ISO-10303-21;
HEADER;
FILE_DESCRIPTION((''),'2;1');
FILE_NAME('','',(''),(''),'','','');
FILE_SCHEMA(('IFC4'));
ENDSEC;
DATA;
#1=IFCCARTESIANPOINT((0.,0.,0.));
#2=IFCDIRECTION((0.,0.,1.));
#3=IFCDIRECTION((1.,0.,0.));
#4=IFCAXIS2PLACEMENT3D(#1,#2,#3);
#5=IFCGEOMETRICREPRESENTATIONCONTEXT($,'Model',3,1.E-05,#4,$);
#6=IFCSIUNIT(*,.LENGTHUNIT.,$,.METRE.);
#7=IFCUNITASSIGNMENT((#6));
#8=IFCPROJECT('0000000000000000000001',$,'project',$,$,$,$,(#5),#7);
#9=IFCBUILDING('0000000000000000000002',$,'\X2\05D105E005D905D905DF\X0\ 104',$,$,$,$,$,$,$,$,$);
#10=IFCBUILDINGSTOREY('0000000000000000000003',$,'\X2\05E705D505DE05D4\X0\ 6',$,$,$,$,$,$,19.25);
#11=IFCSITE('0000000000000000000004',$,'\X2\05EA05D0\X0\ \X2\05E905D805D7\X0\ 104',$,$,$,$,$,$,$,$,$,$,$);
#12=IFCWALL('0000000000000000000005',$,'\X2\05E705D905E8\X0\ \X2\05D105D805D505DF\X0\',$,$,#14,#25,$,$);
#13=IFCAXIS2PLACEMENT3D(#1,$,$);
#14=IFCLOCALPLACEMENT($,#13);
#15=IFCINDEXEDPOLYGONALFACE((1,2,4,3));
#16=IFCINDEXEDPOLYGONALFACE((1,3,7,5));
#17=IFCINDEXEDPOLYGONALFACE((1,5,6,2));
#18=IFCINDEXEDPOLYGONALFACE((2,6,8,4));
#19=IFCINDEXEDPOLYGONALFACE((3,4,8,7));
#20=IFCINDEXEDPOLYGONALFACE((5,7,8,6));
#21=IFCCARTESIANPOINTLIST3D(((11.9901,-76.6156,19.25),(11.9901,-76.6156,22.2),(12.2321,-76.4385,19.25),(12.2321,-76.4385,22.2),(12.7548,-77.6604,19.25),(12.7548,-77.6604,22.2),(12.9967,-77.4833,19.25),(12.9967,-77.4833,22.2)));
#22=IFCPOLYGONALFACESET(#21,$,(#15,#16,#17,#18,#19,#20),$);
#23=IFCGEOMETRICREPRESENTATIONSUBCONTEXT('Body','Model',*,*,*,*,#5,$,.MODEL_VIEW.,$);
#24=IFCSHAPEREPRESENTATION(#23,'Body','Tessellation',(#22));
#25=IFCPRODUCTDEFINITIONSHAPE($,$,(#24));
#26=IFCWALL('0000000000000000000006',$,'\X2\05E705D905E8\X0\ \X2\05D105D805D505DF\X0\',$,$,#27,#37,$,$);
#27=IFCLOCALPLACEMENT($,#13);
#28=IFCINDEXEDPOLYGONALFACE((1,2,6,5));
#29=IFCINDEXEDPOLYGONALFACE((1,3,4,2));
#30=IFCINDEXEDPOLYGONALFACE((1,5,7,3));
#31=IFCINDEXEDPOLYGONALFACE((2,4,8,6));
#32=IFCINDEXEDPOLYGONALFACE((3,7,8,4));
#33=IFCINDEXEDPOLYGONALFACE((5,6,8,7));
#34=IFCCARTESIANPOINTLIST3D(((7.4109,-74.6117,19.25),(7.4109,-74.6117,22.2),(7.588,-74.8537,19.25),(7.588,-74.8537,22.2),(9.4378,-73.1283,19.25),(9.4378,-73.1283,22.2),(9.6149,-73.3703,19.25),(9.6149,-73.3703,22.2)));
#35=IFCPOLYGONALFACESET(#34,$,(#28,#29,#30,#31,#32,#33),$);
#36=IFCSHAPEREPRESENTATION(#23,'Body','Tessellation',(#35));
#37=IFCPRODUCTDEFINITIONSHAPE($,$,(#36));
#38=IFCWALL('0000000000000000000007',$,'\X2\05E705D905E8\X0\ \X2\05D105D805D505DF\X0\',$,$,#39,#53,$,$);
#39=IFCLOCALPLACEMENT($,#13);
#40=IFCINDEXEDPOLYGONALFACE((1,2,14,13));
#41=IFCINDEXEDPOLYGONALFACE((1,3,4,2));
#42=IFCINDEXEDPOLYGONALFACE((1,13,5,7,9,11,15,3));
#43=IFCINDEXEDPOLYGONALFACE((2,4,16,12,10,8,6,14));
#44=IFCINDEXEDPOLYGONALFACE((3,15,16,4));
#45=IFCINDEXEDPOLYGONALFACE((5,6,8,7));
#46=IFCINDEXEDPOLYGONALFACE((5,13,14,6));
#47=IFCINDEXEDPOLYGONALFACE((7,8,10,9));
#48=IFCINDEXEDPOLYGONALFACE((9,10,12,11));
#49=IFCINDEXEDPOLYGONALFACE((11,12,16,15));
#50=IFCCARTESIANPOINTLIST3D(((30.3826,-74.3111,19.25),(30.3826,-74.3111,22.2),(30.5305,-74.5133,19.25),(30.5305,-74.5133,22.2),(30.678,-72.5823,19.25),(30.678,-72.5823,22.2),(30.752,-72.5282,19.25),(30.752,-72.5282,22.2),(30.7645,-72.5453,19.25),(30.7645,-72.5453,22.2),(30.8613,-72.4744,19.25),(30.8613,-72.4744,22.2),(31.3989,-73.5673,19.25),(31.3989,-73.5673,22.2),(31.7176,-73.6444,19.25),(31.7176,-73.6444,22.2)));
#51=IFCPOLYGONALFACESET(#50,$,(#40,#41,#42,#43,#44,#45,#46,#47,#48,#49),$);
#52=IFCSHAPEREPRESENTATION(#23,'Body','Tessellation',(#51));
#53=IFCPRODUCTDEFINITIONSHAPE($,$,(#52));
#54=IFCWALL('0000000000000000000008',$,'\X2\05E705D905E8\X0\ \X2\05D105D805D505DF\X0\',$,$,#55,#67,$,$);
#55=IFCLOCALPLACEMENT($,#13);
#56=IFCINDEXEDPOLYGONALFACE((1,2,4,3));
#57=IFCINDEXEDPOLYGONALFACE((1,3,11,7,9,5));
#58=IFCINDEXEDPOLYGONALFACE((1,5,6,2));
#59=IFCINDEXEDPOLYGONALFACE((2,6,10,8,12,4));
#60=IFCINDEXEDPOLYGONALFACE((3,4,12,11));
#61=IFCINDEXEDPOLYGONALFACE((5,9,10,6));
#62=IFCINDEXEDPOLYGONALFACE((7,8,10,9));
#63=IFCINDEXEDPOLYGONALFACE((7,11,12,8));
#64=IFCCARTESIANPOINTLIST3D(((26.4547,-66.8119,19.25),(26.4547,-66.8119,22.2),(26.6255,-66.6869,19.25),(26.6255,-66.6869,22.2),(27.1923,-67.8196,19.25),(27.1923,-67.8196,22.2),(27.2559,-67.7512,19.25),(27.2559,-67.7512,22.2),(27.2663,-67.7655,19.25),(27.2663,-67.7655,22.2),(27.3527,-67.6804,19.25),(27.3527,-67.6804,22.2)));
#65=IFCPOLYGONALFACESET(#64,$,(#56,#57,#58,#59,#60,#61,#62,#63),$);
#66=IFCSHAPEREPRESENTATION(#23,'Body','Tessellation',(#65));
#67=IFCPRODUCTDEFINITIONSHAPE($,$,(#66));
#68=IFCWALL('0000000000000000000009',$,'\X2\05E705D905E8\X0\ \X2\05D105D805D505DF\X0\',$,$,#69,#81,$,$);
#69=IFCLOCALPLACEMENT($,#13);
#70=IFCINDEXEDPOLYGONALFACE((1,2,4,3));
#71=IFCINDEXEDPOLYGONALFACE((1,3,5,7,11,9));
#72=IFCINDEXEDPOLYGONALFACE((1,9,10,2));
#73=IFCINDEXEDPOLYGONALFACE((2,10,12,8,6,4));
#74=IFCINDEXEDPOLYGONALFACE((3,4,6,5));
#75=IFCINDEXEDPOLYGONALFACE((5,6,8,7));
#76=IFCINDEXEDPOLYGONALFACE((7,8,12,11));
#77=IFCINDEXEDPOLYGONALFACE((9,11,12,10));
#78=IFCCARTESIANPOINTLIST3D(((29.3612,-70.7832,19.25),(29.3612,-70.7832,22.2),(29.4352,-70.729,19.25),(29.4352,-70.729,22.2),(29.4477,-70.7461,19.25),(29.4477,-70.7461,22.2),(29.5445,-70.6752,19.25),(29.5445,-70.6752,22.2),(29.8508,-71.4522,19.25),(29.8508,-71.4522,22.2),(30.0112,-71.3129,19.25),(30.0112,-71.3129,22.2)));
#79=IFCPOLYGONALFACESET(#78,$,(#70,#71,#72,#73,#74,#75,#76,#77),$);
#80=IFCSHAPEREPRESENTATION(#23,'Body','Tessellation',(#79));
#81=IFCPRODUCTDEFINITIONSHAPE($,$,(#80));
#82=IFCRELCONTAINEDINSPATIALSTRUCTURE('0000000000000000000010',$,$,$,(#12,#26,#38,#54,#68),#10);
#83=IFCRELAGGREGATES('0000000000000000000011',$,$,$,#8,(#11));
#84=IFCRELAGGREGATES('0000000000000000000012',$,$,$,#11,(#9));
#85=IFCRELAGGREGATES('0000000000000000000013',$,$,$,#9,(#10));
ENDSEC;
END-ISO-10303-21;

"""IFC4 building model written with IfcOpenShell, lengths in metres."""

from ifc_helpers import new_model, si_unit, frame, origin_with_axes, context, subcontext, project, spatial, polyline, outline, extrude, element, save


model = new_model("IFC4")

# Units and contexts
model_context = context("Model", 3, precision=1e-05, world=origin_with_axes())
body_context = subcontext(model_context, "Body", "Model", "MODEL_VIEW")
ifc_project = project(units=[si_unit("LENGTHUNIT", "METRE")], contexts=[model_context])

# Site, building, storey
site = spatial("IfcSite", under=ifc_project, Name="תא שטח 104")
building = spatial("IfcBuilding", under=site, Name="בניין 104")
storey = spatial("IfcBuildingStorey", under=building, Name="קומה 6", Elevation=19.25)

# Walls
element("IfcWall", 1, inside=storey, Name="קיר בטון", context=body_context, shape_type="SweptSolid", body=[
    extrude(outline(polyline([(12.7548, -77.6604), (12.9967, -77.4833), (12.2321, -76.4385), (11.9901, -76.6156), (12.7548, -77.6604)])), frame((0.0, 0.0, 19.25)), (0.0, 0.0, 1.0), 2.95),
])
element("IfcWall", 2, inside=storey, Name="קיר בטון", context=body_context, shape_type="SweptSolid", body=[
    extrude(outline(polyline([(9.6149, -73.3703), (9.4378, -73.1283), (7.4109, -74.6117), (7.588, -74.8537), (9.6149, -73.3703)])), frame((0.0, 0.0, 19.25)), (0.0, 0.0, 1.0), 2.95),
])
element("IfcWall", 3, inside=storey, Name="קיר בטון", context=body_context, shape_type="SweptSolid", body=[
    extrude(outline(polyline([(30.678, -72.5823), (31.3989, -73.5673), (30.3826, -74.3111), (30.5305, -74.5133), (31.7176, -73.6444), (30.8613, -72.4744), (30.7645, -72.5453), (30.752, -72.5282), (30.678, -72.5823)])), frame((0.0, 0.0, 19.25)), (0.0, 0.0, 1.0), 2.95),
])
element("IfcWall", 4, inside=storey, Name="קיר בטון", context=body_context, shape_type="SweptSolid", body=[
    extrude(outline(polyline([(26.4547, -66.8119), (27.1923, -67.8196), (27.2663, -67.7655), (27.2559, -67.7512), (27.3527, -67.6804), (26.6255, -66.6869), (26.4547, -66.8119)])), frame((0.0, 0.0, 19.25)), (0.0, 0.0, 1.0), 2.95),
])
element("IfcWall", 5, inside=storey, Name="קיר בטון", context=body_context, shape_type="SweptSolid", body=[
    extrude(outline(polyline([(29.4352, -70.729), (29.3612, -70.7832), (29.8508, -71.4522), (30.0112, -71.3129), (29.5445, -70.6752), (29.4477, -70.7461), (29.4352, -70.729)])), frame((0.0, 0.0, 19.25)), (0.0, 0.0, 1.0), 2.95),
])

save(model, "model.ifc")
